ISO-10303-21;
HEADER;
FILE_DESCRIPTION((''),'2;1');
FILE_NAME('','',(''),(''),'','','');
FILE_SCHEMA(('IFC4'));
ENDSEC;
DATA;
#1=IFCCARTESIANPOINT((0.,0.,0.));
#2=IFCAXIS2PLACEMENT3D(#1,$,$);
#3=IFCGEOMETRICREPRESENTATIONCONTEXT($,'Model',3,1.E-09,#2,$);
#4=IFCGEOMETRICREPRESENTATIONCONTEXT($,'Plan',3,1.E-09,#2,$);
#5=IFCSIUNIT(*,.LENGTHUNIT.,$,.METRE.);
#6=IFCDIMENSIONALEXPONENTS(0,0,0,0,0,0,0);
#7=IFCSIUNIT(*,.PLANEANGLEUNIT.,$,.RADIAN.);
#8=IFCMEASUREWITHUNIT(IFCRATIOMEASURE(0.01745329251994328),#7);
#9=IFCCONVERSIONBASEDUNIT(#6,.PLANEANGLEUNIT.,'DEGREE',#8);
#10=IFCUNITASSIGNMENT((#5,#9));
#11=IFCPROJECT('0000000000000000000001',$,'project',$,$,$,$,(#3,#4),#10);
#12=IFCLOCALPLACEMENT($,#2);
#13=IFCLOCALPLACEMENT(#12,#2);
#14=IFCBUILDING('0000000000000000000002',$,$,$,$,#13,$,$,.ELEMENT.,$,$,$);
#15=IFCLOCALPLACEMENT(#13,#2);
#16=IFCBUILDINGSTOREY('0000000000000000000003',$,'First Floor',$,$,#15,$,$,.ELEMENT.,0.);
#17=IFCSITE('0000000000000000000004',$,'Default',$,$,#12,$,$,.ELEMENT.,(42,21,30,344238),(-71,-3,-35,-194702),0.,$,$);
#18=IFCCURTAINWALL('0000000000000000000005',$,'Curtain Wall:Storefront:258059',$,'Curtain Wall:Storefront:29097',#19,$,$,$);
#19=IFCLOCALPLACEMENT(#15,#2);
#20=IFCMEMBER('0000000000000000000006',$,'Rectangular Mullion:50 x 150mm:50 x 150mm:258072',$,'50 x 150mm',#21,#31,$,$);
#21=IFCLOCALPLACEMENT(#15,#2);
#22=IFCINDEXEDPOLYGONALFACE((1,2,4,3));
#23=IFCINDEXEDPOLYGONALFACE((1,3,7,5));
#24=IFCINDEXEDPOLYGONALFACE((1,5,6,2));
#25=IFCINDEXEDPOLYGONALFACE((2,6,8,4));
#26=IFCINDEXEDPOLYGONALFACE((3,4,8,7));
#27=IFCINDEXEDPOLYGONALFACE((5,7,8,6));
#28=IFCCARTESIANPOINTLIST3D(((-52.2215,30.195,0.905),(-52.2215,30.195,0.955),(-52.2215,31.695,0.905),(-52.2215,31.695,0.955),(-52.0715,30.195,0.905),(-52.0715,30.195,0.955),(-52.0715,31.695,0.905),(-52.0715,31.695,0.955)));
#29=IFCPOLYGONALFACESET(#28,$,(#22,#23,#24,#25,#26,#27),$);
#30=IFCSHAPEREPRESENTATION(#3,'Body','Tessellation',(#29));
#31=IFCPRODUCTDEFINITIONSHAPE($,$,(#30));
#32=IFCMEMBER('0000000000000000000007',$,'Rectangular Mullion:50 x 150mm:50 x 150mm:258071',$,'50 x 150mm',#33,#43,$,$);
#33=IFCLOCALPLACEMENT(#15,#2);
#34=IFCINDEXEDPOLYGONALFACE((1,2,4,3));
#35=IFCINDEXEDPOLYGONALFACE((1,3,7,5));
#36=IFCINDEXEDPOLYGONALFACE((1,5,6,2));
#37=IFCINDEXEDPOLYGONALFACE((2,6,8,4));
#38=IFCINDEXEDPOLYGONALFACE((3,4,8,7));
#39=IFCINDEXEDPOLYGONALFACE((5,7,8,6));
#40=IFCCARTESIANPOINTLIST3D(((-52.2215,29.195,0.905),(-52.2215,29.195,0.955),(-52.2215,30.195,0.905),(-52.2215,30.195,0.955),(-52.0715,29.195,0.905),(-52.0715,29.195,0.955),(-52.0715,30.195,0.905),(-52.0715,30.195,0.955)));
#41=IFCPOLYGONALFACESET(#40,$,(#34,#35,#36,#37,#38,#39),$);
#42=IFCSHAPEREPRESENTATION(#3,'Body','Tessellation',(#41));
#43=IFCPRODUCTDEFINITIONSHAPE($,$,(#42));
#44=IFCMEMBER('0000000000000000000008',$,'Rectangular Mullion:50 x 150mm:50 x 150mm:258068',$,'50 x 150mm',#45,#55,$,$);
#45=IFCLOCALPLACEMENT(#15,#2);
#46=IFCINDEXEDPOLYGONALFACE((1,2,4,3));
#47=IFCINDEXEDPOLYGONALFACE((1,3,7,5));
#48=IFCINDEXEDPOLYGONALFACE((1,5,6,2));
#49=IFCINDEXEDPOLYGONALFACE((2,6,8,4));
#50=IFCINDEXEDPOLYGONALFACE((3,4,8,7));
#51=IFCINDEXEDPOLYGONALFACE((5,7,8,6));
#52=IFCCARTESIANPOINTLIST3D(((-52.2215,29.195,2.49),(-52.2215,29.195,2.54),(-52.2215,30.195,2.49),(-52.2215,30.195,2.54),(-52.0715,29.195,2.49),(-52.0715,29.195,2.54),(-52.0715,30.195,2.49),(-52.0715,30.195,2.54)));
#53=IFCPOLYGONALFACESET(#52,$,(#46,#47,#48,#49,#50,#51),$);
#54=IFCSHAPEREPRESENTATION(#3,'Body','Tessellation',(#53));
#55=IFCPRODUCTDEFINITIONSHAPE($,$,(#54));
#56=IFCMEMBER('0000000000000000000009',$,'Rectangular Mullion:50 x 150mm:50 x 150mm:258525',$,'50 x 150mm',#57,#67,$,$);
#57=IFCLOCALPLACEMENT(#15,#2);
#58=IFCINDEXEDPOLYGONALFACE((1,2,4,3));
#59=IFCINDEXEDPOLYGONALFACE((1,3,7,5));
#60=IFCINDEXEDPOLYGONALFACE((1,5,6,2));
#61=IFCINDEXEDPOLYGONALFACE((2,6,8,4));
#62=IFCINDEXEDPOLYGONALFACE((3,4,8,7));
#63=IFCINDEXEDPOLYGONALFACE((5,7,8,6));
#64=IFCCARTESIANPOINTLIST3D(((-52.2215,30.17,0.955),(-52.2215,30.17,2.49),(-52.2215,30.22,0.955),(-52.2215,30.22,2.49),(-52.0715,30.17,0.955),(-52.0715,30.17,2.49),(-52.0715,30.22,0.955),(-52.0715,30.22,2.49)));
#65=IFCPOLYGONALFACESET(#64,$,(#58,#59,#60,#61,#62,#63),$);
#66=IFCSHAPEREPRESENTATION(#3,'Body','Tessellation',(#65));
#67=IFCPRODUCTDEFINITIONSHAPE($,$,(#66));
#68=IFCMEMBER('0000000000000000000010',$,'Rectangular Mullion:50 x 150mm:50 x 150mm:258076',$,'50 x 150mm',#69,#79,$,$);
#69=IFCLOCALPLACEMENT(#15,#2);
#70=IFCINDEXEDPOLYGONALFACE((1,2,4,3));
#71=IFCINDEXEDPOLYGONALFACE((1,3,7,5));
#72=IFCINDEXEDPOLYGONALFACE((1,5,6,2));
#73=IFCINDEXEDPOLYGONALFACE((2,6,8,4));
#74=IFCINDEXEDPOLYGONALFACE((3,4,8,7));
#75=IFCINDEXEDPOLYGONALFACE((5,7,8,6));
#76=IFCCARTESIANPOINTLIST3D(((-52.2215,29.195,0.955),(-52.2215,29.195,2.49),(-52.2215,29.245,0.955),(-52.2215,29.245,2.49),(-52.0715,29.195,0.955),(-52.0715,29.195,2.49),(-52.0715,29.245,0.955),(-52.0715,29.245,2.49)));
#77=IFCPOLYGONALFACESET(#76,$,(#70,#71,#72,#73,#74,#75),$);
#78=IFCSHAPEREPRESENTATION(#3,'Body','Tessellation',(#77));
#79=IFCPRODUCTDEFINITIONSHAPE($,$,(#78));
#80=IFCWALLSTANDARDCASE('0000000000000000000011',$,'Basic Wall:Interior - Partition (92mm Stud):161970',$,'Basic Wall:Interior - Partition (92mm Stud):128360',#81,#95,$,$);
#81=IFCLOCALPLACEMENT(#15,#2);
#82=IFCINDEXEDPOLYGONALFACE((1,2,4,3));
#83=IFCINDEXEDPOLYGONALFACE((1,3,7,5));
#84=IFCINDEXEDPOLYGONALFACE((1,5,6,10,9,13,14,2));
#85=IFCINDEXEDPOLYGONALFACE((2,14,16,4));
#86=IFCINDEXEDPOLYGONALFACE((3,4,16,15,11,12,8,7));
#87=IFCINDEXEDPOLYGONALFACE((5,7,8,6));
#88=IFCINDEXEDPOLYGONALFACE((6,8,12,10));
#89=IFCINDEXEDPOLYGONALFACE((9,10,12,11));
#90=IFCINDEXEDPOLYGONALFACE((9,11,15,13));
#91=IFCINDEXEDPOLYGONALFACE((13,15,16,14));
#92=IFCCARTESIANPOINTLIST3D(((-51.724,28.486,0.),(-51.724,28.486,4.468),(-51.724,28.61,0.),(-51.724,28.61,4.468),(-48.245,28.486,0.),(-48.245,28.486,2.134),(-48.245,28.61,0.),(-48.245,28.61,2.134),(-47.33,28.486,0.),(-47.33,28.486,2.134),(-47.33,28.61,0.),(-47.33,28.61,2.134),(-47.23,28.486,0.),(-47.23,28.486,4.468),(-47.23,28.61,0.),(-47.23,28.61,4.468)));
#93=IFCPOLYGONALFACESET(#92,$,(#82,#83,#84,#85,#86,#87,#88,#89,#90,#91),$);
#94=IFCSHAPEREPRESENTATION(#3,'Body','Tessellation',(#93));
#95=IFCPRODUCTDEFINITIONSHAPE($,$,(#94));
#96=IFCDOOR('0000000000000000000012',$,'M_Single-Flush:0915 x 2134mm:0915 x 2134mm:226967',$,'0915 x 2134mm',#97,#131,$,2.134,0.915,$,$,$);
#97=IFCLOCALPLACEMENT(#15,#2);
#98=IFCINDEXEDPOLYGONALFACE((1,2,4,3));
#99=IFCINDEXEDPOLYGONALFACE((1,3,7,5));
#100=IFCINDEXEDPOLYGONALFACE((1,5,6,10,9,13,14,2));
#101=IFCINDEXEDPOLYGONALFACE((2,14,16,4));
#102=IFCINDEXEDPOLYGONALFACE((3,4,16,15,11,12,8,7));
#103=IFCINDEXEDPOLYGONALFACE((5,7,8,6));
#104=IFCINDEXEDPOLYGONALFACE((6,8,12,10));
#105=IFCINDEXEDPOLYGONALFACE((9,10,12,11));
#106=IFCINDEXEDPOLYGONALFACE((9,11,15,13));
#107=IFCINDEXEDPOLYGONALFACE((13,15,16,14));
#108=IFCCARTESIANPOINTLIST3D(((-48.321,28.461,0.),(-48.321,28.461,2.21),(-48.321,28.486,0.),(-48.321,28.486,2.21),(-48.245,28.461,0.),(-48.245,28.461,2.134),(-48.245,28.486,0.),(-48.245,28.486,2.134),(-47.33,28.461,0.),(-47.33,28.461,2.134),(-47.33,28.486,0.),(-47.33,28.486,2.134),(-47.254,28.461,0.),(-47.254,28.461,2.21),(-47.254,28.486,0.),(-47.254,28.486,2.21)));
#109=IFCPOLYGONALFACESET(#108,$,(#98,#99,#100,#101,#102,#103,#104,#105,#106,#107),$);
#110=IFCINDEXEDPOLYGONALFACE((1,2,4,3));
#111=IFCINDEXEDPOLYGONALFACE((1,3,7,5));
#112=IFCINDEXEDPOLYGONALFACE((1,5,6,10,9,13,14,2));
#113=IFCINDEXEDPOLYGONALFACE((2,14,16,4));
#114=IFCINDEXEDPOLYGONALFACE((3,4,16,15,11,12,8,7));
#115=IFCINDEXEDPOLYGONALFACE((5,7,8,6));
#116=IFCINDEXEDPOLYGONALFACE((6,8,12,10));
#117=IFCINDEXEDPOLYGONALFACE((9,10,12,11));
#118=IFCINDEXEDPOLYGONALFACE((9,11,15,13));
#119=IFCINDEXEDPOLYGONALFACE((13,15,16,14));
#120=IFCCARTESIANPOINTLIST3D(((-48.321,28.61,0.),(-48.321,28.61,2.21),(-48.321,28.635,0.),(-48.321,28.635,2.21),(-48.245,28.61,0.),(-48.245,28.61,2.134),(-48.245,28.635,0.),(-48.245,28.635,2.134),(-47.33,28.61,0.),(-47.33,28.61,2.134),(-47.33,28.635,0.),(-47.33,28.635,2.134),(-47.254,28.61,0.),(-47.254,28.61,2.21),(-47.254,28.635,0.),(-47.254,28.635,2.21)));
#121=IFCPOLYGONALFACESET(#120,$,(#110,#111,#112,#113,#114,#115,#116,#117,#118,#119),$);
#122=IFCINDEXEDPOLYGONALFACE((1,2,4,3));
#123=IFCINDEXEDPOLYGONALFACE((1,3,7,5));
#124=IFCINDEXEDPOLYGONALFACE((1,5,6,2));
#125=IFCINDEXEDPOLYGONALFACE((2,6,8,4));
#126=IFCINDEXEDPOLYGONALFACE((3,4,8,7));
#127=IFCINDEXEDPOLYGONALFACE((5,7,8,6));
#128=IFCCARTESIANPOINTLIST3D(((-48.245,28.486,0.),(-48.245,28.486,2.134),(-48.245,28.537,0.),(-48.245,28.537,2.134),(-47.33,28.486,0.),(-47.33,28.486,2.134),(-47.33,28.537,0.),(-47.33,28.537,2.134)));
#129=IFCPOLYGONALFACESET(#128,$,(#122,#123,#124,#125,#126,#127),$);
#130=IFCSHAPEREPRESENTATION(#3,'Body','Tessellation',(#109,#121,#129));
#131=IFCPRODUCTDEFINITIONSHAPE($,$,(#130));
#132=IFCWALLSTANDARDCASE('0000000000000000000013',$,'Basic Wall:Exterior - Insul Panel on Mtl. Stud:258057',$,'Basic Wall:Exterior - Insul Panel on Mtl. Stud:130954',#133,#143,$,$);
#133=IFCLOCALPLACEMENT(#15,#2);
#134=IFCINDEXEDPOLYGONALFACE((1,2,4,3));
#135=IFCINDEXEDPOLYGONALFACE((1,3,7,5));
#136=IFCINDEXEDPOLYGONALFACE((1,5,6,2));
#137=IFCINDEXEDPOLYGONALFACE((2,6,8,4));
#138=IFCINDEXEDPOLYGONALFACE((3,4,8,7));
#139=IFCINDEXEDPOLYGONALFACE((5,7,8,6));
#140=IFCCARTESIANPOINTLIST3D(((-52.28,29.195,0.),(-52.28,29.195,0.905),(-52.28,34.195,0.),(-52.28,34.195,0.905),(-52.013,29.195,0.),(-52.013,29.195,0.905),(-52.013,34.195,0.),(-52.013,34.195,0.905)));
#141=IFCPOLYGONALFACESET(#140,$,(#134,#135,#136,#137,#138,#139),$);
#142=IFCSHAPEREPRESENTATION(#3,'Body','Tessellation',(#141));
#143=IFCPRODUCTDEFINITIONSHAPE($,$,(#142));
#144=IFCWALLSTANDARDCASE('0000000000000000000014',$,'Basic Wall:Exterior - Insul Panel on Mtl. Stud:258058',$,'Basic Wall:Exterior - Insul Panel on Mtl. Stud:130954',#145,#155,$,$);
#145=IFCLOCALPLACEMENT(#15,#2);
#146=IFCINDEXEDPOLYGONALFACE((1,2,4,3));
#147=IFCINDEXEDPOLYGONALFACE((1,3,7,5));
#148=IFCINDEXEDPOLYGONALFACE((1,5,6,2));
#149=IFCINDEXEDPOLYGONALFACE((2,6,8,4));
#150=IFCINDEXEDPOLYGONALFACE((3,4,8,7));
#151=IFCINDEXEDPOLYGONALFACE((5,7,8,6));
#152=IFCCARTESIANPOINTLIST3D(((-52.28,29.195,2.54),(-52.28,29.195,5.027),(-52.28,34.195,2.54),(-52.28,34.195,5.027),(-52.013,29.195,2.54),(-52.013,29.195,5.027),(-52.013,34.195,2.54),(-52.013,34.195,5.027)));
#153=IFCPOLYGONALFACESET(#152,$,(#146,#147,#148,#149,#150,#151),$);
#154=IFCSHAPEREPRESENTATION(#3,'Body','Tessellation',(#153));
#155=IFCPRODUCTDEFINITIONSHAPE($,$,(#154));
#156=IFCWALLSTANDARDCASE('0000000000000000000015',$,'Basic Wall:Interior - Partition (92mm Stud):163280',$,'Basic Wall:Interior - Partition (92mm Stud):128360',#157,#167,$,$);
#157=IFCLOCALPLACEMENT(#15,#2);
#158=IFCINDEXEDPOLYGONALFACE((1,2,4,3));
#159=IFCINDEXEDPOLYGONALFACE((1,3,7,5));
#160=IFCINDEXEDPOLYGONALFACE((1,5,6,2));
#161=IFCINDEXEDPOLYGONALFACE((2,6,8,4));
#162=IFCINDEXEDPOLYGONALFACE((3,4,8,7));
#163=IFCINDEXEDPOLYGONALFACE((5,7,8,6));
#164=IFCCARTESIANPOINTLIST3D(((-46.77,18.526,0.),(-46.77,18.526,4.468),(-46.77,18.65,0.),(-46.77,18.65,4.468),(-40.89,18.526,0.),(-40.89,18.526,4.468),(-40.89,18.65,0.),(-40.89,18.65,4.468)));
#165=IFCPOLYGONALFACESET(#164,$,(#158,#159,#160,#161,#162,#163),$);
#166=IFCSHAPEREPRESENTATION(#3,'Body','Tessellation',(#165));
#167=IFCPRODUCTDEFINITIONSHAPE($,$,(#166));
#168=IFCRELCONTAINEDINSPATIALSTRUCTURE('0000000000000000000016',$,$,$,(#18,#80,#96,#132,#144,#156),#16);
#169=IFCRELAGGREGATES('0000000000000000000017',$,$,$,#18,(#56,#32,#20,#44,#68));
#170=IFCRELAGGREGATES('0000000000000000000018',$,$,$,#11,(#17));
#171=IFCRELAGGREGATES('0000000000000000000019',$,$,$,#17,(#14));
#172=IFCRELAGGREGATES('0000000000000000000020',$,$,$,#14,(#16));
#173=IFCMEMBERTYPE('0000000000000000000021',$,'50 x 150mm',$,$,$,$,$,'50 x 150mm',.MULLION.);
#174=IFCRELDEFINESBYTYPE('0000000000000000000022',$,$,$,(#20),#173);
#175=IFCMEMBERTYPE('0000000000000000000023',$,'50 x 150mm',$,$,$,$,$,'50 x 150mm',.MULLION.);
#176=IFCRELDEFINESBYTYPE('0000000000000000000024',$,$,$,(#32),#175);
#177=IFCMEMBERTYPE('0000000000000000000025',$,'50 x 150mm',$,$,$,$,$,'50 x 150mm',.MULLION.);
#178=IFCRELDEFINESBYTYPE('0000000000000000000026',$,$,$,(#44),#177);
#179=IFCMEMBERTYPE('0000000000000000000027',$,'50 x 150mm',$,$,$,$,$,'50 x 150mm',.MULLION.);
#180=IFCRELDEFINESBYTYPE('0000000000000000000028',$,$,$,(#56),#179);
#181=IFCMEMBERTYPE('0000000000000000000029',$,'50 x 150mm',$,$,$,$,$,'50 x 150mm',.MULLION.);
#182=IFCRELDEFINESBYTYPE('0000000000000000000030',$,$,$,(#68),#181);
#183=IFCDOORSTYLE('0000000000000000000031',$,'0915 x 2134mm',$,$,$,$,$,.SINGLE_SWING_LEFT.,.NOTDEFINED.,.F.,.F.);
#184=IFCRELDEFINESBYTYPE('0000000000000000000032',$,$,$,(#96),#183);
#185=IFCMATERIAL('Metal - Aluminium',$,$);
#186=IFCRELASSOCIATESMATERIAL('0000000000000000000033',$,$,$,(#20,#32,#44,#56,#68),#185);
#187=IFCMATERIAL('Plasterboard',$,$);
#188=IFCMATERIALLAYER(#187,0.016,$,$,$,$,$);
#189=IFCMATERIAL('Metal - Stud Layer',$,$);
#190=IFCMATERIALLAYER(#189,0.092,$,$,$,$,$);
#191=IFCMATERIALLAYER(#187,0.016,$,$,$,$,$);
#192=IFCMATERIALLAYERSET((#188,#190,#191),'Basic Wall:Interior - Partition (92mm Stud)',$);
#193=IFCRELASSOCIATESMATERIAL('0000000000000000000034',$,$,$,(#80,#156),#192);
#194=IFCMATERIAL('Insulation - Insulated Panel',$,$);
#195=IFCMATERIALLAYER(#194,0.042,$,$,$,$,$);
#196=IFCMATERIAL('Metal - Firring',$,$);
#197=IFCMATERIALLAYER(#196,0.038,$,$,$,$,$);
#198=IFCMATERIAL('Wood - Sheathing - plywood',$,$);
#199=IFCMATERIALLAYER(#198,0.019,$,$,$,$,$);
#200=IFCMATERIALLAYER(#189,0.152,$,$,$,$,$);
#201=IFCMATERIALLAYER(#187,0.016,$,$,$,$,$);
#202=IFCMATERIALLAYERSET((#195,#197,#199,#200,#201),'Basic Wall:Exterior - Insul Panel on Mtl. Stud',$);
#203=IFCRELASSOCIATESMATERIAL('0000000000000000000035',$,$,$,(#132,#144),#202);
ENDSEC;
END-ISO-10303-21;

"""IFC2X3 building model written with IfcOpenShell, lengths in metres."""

from ifc_helpers import new_model, entity, si_unit, converted_unit, frame, frame_2d, origin, origin_2d_with_axis, place, context, project, spatial, polyline, rectangle, outline, extrude, source, transform, mapped, material, layer, layer_set, layer_usage, type_object, type_shapes, element, fill, aggregate, save


model = new_model("IFC2X3")

# Units and contexts
model_context = context("Model", 3, precision=1e-09, world=origin())
plan_context = context("Plan", 3, precision=1e-09, world=origin())
ifc_project = project(units=[si_unit("LENGTHUNIT", "METRE"), converted_unit("PLANEANGLEUNIT", "DEGREE", entity("IfcRatioMeasure", 0.01745329251994328), si_unit("PLANEANGLEUNIT", "RADIAN"), dimensions=[0, 0, 0, 0, 0, 0, 0])], contexts=[model_context, plan_context])

# Site, building, storey
site_placement = place(None, origin())
site = spatial("IfcSite", under=ifc_project, at=site_placement, Name="Default", CompositionType="ELEMENT", RefLatitude=(42, 21, 30, 344238), RefLongitude=(-71, -3, -35, -194702), RefElevation=0.0)
building_placement = place(site_placement, origin())
building = spatial("IfcBuilding", under=site, at=building_placement, CompositionType="ELEMENT")
storey_placement = place(building_placement, origin())
storey = spatial("IfcBuildingStorey", under=building, at=storey_placement, Name="First Floor", CompositionType="ELEMENT", Elevation=0.0)

# Curtain wall, members
curtain_wall_placement = place(storey_placement, origin())
curtain_wall = element("IfcCurtainWall", 1, at=curtain_wall_placement, inside=storey, Name="Curtain Wall:Storefront:258059", ObjectType="Curtain Wall:Storefront:29097")
ifc_material_1 = material(Name="Metal - Aluminium")
member_type_1 = type_object("IfcMemberType", Name="50 x 150mm", ElementType="50 x 150mm", PredefinedType="MULLION")
shared_shape_1 = source(origin(), model_context, "Body", "SweptSolid", [
    extrude(rectangle(XDim=0.05, YDim=0.15, at=origin_2d_with_axis()), frame((-0.025, 0.0, -1.5), z_axis=(0.0, 0.0, 1.0), x_axis=(-1.0, 0.0, 0.0)), (0.0, 0.0, 1.0), 1.5),
])
type_shapes(member_type_1, [shared_shape_1])
member_1_placement = place(storey_placement, frame((-52.1465, 30.195, 0.905), z_axis=(0.0, -1.0, 0.0), x_axis=(0.0, 0.0, -1.0)))
member_1 = element("IfcMember", 2, at=member_1_placement, type_object=member_type_1, material=ifc_material_1, Name="Rectangular Mullion:50 x 150mm:50 x 150mm:258072", ObjectType="50 x 150mm", context=model_context, shape_type="MappedRepresentation", body=[
    mapped(shared_shape_1, transform((0.0, 0.0, 0.0), scale=1.0)),
])
member_type_2 = type_object("IfcMemberType", Name="50 x 150mm", ElementType="50 x 150mm", PredefinedType="MULLION")
shared_shape_2 = source(origin(), model_context, "Body", "SweptSolid", [
    extrude(rectangle(XDim=0.05, YDim=0.15, at=origin_2d_with_axis()), frame((-0.025, 0.0, -1.0), z_axis=(0.0, 0.0, 1.0), x_axis=(-1.0, 0.0, 0.0)), (0.0, 0.0, 1.0), 1.0),
])
type_shapes(member_type_2, [shared_shape_2])
member_2_placement = place(storey_placement, frame((-52.1465, 29.195, 0.905), z_axis=(0.0, -1.0, 0.0), x_axis=(0.0, 0.0, -1.0)))
member_2 = element("IfcMember", 3, at=member_2_placement, type_object=member_type_2, material=ifc_material_1, Name="Rectangular Mullion:50 x 150mm:50 x 150mm:258071", ObjectType="50 x 150mm", context=model_context, shape_type="MappedRepresentation", body=[
    mapped(shared_shape_2, transform((0.0, 0.0, 0.0), scale=1.0)),
])
member_type_3 = type_object("IfcMemberType", Name="50 x 150mm", ElementType="50 x 150mm", PredefinedType="MULLION")
type_shapes(member_type_3, [shared_shape_2])
member_3_placement = place(storey_placement, frame((-52.1465, 30.195, 2.54), z_axis=(0.0, 1.0, 0.0), x_axis=(0.0, 0.0, 1.0)))
member_3 = element("IfcMember", 4, at=member_3_placement, type_object=member_type_3, material=ifc_material_1, Name="Rectangular Mullion:50 x 150mm:50 x 150mm:258068", ObjectType="50 x 150mm", context=model_context, shape_type="MappedRepresentation", body=[
    mapped(shared_shape_2, transform((0.0, 0.0, 0.0), scale=1.0)),
])
member_type_4 = type_object("IfcMemberType", Name="50 x 150mm", ElementType="50 x 150mm", PredefinedType="MULLION")
shared_shape_3 = source(origin(), model_context, "Body", "SweptSolid", [
    extrude(rectangle(XDim=0.05, YDim=0.15, at=origin_2d_with_axis()), frame((0.0, 0.0, -1.535), z_axis=(0.0, 0.0, 1.0), x_axis=(-1.0, 0.0, 0.0)), (0.0, 0.0, 1.0), 1.535),
])
type_shapes(member_type_4, [shared_shape_3])
member_4_placement = place(storey_placement, frame((-52.1465, 30.195, 0.955), z_axis=(0.0, 0.0, -1.0), x_axis=(0.0, 1.0, 0.0)))
member_4 = element("IfcMember", 5, at=member_4_placement, type_object=member_type_4, material=ifc_material_1, Name="Rectangular Mullion:50 x 150mm:50 x 150mm:258525", ObjectType="50 x 150mm", context=model_context, shape_type="MappedRepresentation", body=[
    mapped(shared_shape_3, transform((0.0, 0.0, 0.0), scale=1.0)),
])
member_type_5 = type_object("IfcMemberType", Name="50 x 150mm", ElementType="50 x 150mm", PredefinedType="MULLION")
shared_shape_4 = source(origin(), model_context, "Body", "SweptSolid", [
    extrude(rectangle(XDim=0.05, YDim=0.15, at=origin_2d_with_axis()), frame((-0.025, 0.0, -1.535), z_axis=(0.0, 0.0, 1.0), x_axis=(-1.0, 0.0, 0.0)), (0.0, 0.0, 1.0), 1.535),
])
type_shapes(member_type_5, [shared_shape_4])
member_5_placement = place(storey_placement, frame((-52.1465, 29.195, 2.49), z_axis=(0.0, 0.0, 1.0), x_axis=(0.0, -1.0, 0.0)))
member_5 = element("IfcMember", 6, at=member_5_placement, type_object=member_type_5, material=ifc_material_1, Name="Rectangular Mullion:50 x 150mm:50 x 150mm:258076", ObjectType="50 x 150mm", context=model_context, shape_type="MappedRepresentation", body=[
    mapped(shared_shape_4, transform((0.0, 0.0, 0.0), scale=1.0)),
])
aggregate(curtain_wall, [member_4, member_2, member_1, member_3, member_5])

# Wall, opening, door
ifc_material_2 = material(Name="Plasterboard")
ifc_layer_1 = layer(ifc_material_2, 0.016)
ifc_material_3 = material(Name="Metal - Stud Layer")
ifc_layer_2 = layer(ifc_material_3, 0.092)
ifc_layer_3 = layer(ifc_material_2, 0.016)
ifc_layer_set_1 = layer_set([ifc_layer_1, ifc_layer_2, ifc_layer_3], Name="Basic Wall:Interior - Partition (92mm Stud)")
ifc_layer_usage_1 = layer_usage(ifc_layer_set_1, "AXIS2", "NEGATIVE", 0.062)
wall_1_placement = place(storey_placement, frame((-51.724, 28.548, 0.0)))
wall_1 = element("IfcWallStandardCase", 7, at=wall_1_placement, inside=storey, material=ifc_layer_usage_1, Name="Basic Wall:Interior - Partition (92mm Stud):161970", ObjectType="Basic Wall:Interior - Partition (92mm Stud):128360", context=model_context, shape_type="SweptSolid", body=[
    extrude(rectangle(XDim=4.494, YDim=0.124, at=frame_2d((2.247, 0.0), x_axis=(-1.0, 0.0))), origin(), (0.0, 0.0, 1.0), 4.468),
])
opening_1_placement = place(wall_1_placement, frame((4.394, 0.062, 0.0)))
opening_1 = element("IfcOpeningElement", 8, at=opening_1_placement, cuts=wall_1, ObjectType="Opening", context=model_context, shape_type="SweptSolid", body=[
    extrude(rectangle(XDim=0.915, YDim=2.134, at=frame_2d((1.067, 0.4575), x_axis=(0.0, -1.0))), frame((0.0, 0.0, 0.0), z_axis=(0.0, -1.0, 0.0), x_axis=(0.0, 0.0, 1.0)), (0.0, 0.0, 1.0), 0.124),
])
door_style = type_object("IfcDoorStyle", Name="0915 x 2134mm", ConstructionType="NOTDEFINED", OperationType="SINGLE_SWING_LEFT", ParameterTakesPrecedence=False, Sizeable=False)
shared_shape_5 = source(origin(), model_context, "Body", "SweptSolid", [
    extrude(outline(polyline([(-0.5335, -1.124), (0.5335, -1.124), (0.5335, 1.086), (0.4575, 1.086), (0.4575, -1.048), (-0.4575, -1.048), (-0.4575, 1.086), (-0.5335, 1.086), (-0.5335, -1.124)])), frame((0.4575, 0.149, 1.086), z_axis=(0.0, -1.0, 0.0), x_axis=(-1.0, 0.0, 0.0)), (0.0, 0.0, 1.0), 0.025),
    extrude(outline(polyline([(-1.124, -0.5335), (1.086, -0.5335), (1.086, -0.4575), (-1.048, -0.4575), (-1.048, 0.4575), (1.086, 0.4575), (1.086, 0.5335), (-1.124, 0.5335), (-1.124, -0.5335)])), frame((0.4575, 0.0, 1.086), z_axis=(0.0, -1.0, 0.0), x_axis=(0.0, 0.0, -1.0)), (0.0, 0.0, 1.0), 0.025),
    extrude(rectangle(XDim=0.915, YDim=0.051, at=origin_2d_with_axis()), frame((0.4575, 0.0985, 0.0)), (0.0, 0.0, 1.0), 2.134),
])
type_shapes(door_style, [shared_shape_5])
door_1_placement = place(opening_1_placement, frame((0.0, 0.0, 0.0), z_axis=(0.0, 0.0, 1.0), x_axis=(-1.0, 0.0, 0.0)))
door_1 = element("IfcDoor", 9, at=door_1_placement, inside=storey, type_object=door_style, Name="M_Single-Flush:0915 x 2134mm:0915 x 2134mm:226967", ObjectType="0915 x 2134mm", OverallHeight=2.134, OverallWidth=0.915, context=model_context, shape_type="MappedRepresentation", body=[
    mapped(shared_shape_5, transform((0.0, 0.0, 0.0), scale=1.0)),
])
fill(opening_1, door_1)

# Walls
ifc_material_4 = material(Name="Insulation - Insulated Panel")
ifc_layer_4 = layer(ifc_material_4, 0.042)
ifc_material_5 = material(Name="Metal - Firring")
ifc_layer_5 = layer(ifc_material_5, 0.038)
ifc_material_6 = material(Name="Wood - Sheathing - plywood")
ifc_layer_6 = layer(ifc_material_6, 0.019)
ifc_layer_7 = layer(ifc_material_3, 0.152)
ifc_layer_8 = layer(ifc_material_2, 0.016)
ifc_layer_set_2 = layer_set([ifc_layer_4, ifc_layer_5, ifc_layer_6, ifc_layer_7, ifc_layer_8], Name="Basic Wall:Exterior - Insul Panel on Mtl. Stud")
ifc_layer_usage_2 = layer_usage(ifc_layer_set_2, "AXIS2", "NEGATIVE", 0.1335)
wall_2_placement = place(storey_placement, frame((-52.1465, 29.195, 0.0), z_axis=(0.0, 0.0, 1.0), x_axis=(0.0, 1.0, 0.0)))
element("IfcWallStandardCase", 10, at=wall_2_placement, inside=storey, material=ifc_layer_usage_2, Name="Basic Wall:Exterior - Insul Panel on Mtl. Stud:258057", ObjectType="Basic Wall:Exterior - Insul Panel on Mtl. Stud:130954", context=model_context, shape_type="SweptSolid", body=[
    extrude(rectangle(XDim=5.0, YDim=0.267, at=frame_2d((2.5, 0.0), x_axis=(-1.0, 0.0))), origin(), (0.0, 0.0, 1.0), 0.905),
])
wall_3_placement = place(storey_placement, frame((-52.1465, 29.195, 2.54), z_axis=(0.0, 0.0, 1.0), x_axis=(0.0, 1.0, 0.0)))
element("IfcWallStandardCase", 11, at=wall_3_placement, inside=storey, material=ifc_layer_usage_2, Name="Basic Wall:Exterior - Insul Panel on Mtl. Stud:258058", ObjectType="Basic Wall:Exterior - Insul Panel on Mtl. Stud:130954", context=model_context, shape_type="SweptSolid", body=[
    extrude(rectangle(XDim=5.0, YDim=0.267, at=frame_2d((2.5, 0.0), x_axis=(-1.0, 0.0))), origin(), (0.0, 0.0, 1.0), 2.487),
])
wall_4_placement = place(storey_placement, frame((-46.77, 18.588, 0.0)))
element("IfcWallStandardCase", 12, at=wall_4_placement, inside=storey, material=ifc_layer_usage_1, Name="Basic Wall:Interior - Partition (92mm Stud):163280", ObjectType="Basic Wall:Interior - Partition (92mm Stud):128360", context=model_context, shape_type="SweptSolid", body=[
    extrude(rectangle(XDim=5.88, YDim=0.124, at=frame_2d((2.94, 0.0), x_axis=(-1.0, 0.0))), origin(), (0.0, 0.0, 1.0), 4.468),
])

save(model, "model.ifc")
